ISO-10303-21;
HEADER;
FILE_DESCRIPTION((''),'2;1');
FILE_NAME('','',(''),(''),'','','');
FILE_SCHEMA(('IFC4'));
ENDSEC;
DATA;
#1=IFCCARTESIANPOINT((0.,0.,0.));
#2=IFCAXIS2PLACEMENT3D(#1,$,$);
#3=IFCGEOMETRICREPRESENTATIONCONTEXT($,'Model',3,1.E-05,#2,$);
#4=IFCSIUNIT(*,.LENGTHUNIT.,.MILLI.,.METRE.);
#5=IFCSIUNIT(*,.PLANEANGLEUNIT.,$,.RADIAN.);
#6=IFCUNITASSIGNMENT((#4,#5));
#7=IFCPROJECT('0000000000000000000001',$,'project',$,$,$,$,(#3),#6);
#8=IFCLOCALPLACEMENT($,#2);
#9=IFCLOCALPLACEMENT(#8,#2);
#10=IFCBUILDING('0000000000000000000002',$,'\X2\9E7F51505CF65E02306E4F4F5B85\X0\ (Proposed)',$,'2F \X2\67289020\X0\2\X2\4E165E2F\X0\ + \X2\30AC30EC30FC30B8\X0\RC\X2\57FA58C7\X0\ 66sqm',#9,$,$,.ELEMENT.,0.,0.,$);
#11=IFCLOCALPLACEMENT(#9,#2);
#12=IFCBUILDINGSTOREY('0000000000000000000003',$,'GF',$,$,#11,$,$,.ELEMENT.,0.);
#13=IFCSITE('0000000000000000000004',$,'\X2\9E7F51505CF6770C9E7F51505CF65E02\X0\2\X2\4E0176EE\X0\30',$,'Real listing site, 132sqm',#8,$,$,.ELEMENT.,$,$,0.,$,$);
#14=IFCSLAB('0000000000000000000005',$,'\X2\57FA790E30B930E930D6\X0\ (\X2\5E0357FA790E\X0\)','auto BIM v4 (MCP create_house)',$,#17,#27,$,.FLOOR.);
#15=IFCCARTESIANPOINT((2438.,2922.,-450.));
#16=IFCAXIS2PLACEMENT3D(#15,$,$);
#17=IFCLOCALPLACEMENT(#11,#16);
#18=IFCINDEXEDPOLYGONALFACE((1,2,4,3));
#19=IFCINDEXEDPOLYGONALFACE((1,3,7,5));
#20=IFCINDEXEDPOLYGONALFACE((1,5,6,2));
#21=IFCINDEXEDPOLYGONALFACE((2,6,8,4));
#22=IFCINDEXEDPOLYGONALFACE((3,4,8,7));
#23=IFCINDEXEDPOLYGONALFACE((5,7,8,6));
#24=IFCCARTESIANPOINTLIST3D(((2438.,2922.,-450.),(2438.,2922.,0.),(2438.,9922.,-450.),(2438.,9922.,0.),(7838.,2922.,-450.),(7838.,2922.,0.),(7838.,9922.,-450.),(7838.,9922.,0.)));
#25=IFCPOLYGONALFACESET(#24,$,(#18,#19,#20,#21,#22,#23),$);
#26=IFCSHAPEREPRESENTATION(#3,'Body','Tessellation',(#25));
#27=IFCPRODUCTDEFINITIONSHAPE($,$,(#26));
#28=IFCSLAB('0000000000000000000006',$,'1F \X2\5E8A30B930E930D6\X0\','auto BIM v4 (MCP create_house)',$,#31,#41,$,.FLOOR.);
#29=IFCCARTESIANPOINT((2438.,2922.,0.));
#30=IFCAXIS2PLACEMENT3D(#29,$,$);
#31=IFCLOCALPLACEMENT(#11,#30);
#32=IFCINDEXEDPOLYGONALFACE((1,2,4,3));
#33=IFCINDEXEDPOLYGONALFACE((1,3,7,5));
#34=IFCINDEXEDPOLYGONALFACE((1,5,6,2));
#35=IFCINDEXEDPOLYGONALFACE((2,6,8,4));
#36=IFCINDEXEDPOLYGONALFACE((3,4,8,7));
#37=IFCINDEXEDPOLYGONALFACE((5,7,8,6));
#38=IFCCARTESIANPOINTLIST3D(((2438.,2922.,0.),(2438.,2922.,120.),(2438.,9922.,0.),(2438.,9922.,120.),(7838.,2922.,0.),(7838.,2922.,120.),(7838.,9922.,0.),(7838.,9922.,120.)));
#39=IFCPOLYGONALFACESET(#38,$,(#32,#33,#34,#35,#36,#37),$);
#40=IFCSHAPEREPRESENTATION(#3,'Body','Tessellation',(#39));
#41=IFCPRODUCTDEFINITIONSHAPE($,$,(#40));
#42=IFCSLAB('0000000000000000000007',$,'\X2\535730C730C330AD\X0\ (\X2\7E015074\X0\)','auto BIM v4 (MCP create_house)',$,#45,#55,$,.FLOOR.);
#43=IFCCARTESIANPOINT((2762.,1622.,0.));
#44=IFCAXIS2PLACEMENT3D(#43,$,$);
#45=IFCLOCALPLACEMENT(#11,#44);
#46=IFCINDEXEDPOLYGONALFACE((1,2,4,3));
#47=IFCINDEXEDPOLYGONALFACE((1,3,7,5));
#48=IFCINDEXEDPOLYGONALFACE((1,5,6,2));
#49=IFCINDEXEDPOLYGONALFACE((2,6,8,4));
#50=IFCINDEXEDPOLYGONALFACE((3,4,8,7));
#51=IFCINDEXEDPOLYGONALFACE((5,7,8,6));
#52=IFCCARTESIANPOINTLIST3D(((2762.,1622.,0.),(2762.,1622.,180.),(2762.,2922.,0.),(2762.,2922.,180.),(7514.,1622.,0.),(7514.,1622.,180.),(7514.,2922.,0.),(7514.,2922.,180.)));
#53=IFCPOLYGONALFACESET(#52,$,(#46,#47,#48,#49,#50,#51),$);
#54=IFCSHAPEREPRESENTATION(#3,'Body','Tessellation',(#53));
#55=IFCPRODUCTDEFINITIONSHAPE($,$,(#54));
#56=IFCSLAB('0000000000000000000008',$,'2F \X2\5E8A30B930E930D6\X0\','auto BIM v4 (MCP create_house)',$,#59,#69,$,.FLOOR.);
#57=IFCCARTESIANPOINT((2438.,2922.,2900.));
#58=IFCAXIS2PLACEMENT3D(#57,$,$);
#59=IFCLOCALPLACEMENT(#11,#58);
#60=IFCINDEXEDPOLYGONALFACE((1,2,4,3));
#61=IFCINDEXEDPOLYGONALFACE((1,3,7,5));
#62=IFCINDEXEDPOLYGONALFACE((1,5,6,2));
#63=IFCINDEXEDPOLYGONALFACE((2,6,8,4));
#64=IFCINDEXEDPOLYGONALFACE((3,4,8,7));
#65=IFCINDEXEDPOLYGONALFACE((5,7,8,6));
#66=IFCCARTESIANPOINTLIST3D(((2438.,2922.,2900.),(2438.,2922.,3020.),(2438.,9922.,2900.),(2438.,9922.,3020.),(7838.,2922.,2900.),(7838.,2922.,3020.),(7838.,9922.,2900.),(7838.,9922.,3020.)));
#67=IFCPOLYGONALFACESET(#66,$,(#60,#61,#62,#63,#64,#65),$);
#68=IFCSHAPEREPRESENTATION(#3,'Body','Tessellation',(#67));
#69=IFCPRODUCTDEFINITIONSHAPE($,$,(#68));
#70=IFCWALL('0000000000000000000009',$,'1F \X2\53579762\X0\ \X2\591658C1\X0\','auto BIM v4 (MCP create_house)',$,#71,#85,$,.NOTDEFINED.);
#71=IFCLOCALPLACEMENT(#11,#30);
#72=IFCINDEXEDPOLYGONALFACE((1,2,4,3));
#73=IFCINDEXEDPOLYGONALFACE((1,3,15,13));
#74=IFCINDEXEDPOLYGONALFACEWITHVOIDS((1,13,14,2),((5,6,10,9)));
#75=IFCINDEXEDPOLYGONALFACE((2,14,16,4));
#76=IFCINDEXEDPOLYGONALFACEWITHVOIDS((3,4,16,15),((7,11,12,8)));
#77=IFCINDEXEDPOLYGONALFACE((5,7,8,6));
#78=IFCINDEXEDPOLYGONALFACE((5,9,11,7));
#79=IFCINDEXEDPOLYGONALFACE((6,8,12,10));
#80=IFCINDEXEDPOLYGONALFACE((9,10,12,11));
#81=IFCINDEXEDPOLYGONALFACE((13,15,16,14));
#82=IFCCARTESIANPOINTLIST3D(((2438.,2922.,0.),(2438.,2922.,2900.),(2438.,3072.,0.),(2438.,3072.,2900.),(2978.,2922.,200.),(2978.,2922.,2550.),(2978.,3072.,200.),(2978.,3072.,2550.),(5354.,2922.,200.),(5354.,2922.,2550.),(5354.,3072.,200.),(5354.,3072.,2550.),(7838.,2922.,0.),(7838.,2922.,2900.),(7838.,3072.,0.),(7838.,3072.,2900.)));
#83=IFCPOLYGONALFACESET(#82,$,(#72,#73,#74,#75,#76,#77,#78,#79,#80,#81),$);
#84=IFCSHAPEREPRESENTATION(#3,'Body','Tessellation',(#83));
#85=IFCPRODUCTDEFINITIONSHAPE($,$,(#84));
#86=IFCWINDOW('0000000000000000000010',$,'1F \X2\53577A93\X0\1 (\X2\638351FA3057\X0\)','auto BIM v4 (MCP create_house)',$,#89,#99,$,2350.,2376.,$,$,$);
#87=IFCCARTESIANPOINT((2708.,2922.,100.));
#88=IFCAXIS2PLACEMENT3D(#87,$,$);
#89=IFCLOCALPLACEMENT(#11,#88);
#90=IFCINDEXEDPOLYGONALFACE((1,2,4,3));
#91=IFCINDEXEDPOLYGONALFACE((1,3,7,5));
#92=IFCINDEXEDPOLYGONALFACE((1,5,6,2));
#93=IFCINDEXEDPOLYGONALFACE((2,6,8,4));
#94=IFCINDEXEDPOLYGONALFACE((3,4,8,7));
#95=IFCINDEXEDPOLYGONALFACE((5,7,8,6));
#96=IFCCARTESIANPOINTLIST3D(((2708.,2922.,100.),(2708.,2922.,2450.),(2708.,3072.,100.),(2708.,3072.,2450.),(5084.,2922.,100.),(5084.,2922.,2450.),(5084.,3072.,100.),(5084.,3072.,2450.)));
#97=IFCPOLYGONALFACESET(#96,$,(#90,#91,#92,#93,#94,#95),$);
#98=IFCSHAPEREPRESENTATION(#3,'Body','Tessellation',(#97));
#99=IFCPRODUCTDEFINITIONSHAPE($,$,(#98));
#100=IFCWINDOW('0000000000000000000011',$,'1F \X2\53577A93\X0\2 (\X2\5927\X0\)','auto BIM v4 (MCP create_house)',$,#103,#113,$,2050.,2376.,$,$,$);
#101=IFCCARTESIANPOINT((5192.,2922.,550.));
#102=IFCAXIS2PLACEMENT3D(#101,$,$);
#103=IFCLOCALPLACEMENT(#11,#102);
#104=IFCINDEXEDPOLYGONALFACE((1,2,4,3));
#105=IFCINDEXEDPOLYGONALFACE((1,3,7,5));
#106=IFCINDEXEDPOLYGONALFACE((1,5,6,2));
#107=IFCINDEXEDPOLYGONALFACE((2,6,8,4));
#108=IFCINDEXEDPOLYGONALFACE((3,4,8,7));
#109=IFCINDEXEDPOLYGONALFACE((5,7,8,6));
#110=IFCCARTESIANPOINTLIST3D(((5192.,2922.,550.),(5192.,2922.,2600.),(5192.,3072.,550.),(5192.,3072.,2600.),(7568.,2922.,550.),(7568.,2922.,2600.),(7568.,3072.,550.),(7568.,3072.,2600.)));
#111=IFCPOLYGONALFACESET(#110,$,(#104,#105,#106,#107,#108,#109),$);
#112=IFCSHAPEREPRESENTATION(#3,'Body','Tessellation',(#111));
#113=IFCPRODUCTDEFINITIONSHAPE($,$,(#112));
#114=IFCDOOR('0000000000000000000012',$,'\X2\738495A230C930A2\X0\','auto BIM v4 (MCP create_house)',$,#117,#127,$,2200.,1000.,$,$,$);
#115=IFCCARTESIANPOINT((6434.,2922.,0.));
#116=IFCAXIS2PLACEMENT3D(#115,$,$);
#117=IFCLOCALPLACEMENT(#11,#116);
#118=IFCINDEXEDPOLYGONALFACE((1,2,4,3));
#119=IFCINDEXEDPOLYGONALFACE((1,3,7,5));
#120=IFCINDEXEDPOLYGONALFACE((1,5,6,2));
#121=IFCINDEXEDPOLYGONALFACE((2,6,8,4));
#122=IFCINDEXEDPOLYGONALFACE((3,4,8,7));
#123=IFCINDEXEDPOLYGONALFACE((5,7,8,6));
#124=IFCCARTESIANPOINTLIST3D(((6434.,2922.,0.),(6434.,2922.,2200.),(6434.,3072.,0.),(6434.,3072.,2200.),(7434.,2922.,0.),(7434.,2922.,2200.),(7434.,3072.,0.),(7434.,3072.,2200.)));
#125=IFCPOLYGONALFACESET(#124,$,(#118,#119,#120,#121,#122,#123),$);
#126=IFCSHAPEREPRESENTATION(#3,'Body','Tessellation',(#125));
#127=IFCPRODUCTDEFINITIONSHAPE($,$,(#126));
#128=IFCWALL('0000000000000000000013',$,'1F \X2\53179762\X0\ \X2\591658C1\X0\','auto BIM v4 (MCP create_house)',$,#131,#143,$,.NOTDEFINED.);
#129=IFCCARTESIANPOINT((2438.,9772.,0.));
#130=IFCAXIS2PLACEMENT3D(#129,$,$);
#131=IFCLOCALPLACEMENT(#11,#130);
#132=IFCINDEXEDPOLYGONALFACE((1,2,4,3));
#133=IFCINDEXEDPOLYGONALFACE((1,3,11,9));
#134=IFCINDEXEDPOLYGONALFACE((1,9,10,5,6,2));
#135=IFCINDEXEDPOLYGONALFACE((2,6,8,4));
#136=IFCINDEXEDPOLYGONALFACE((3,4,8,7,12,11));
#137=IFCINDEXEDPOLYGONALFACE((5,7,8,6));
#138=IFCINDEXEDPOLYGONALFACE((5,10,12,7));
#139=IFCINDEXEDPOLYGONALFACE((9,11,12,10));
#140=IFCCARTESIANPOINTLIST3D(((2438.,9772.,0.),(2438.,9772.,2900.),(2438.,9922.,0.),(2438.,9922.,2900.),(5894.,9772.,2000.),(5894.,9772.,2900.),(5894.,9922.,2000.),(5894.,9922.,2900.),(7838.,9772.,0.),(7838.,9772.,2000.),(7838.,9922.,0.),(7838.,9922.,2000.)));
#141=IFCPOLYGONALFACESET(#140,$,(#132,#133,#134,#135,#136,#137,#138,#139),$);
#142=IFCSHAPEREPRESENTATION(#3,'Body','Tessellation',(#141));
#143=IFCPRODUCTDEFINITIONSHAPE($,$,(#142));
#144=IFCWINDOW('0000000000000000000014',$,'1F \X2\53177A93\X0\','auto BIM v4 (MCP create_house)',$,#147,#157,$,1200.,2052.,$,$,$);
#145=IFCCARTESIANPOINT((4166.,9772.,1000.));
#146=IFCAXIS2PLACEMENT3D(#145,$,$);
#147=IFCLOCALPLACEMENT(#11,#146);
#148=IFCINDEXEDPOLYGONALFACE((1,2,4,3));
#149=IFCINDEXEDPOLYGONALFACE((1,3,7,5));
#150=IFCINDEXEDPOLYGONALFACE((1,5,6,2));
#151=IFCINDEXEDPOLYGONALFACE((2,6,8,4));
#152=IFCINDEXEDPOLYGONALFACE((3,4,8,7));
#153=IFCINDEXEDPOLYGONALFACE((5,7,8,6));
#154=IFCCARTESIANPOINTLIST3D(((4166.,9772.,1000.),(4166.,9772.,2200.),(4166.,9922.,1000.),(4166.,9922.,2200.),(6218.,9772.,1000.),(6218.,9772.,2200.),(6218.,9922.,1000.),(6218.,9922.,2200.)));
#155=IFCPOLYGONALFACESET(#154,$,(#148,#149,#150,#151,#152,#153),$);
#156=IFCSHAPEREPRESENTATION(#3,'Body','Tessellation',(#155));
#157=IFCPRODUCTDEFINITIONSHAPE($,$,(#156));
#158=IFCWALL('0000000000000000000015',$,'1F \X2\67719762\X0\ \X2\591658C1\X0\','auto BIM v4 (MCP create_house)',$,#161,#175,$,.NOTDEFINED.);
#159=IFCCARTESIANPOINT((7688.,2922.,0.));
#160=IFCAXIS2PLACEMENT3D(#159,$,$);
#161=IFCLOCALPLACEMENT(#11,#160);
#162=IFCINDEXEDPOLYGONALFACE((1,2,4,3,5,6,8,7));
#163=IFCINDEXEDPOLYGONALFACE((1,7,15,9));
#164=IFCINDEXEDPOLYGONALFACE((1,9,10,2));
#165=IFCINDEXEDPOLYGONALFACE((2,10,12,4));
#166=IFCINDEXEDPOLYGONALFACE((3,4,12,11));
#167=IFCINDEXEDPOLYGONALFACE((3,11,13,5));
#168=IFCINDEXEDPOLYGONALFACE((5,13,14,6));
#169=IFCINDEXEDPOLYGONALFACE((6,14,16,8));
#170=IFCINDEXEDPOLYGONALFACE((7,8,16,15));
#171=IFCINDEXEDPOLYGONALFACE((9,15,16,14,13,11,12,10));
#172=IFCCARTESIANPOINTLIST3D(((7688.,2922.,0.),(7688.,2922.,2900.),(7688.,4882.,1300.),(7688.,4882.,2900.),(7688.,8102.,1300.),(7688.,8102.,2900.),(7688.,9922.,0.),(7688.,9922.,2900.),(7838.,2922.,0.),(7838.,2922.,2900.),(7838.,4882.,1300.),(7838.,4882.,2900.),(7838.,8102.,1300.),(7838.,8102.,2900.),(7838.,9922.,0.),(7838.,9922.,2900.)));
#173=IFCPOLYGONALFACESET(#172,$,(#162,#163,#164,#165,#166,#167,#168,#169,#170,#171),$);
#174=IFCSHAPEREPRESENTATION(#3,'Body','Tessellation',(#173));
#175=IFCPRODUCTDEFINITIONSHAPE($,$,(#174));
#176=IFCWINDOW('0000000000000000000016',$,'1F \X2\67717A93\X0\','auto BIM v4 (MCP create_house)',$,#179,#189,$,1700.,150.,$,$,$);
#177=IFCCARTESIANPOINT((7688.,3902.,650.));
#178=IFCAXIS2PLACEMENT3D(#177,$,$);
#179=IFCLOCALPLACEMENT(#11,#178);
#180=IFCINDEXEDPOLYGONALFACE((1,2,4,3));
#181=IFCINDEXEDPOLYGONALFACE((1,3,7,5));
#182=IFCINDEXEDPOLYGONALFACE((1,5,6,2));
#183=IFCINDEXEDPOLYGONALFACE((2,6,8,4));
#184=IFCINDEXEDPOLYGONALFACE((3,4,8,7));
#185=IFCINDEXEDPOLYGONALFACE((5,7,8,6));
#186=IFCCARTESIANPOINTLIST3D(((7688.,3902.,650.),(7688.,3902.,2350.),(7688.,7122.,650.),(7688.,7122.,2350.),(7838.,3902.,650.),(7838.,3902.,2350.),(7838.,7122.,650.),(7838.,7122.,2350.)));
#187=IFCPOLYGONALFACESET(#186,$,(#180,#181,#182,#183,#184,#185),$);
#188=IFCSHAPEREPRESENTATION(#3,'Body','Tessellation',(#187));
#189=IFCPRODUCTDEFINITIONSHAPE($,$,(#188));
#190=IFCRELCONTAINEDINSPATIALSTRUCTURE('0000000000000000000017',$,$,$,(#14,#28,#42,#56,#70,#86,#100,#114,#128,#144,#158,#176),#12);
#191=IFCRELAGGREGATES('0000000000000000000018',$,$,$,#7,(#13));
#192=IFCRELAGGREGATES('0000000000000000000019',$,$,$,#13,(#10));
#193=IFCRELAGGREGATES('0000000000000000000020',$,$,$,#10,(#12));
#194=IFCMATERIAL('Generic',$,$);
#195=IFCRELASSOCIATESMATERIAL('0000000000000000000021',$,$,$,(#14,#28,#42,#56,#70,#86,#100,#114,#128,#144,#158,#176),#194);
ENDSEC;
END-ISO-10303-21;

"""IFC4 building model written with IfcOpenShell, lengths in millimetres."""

from ifc_helpers import new_model, si_unit, frame, frame_2d, origin, place, context, project, spatial, rectangle, extrude, material, element, fill, save


model = new_model("IFC4")

# Units and contexts
model_context = context("Model", 3, precision=1e-05, world=origin())
ifc_project = project(units=[si_unit("LENGTHUNIT", "METRE", prefix="MILLI"), si_unit("PLANEANGLEUNIT", "RADIAN")], contexts=[model_context])

# Site, building, storey
site_placement = place(None, origin())
site = spatial("IfcSite", under=ifc_project, at=site_placement, Name="鹿児島県鹿児島市2丁目30", ObjectType="Real listing site, 132sqm", CompositionType="ELEMENT", RefElevation=0.0)
building_placement = place(site_placement, origin())
building = spatial("IfcBuilding", under=site, at=building_placement, Name="鹿児島市の住宅 (Proposed)", ObjectType="2F 木造2世帯 + ガレージRC基壇 66sqm", CompositionType="ELEMENT", ElevationOfRefHeight=0.0, ElevationOfTerrain=0.0)
storey_placement = place(building_placement, origin())
storey = spatial("IfcBuildingStorey", under=building, at=storey_placement, Name="GF", CompositionType="ELEMENT", Elevation=0.0)

# Slabs
ifc_material = material(Name="Generic")
slab_1_placement = place(storey_placement, frame((2438.0, 2922.0, -450.0)))
element("IfcSlab", 1, at=slab_1_placement, inside=storey, material=ifc_material, Name="基礎スラブ (布基礎)", Description="auto BIM v4 (MCP create_house)", PredefinedType="FLOOR", context=model_context, shape_type="SweptSolid", body=[
    extrude(rectangle(XDim=5400.0, YDim=7000.0, at=frame_2d((2700.0, 3500.0))), frame((2438.0, 2922.0, -450.0)), (0.0, 0.0, 1.0), 450.0),
])
slab_2_placement = place(storey_placement, frame((2438.0, 2922.0, 0.0)))
element("IfcSlab", 2, at=slab_2_placement, inside=storey, material=ifc_material, Name="1F 床スラブ", Description="auto BIM v4 (MCP create_house)", PredefinedType="FLOOR", context=model_context, shape_type="SweptSolid", body=[
    extrude(rectangle(XDim=5400.0, YDim=7000.0, at=frame_2d((2700.0, 3500.0))), frame((2438.0, 2922.0, 0.0)), (0.0, 0.0, 1.0), 120.0),
])
slab_3_placement = place(storey_placement, frame((2762.0, 1622.0, 0.0)))
element("IfcSlab", 3, at=slab_3_placement, inside=storey, material=ifc_material, Name="南デッキ (縁側)", Description="auto BIM v4 (MCP create_house)", PredefinedType="FLOOR", context=model_context, shape_type="SweptSolid", body=[
    extrude(rectangle(XDim=4752.0, YDim=1300.0, at=frame_2d((2376.0, 650.0))), frame((2762.0, 1622.0, 0.0)), (0.0, 0.0, 1.0), 180.0),
])
slab_4_placement = place(storey_placement, frame((2438.0, 2922.0, 2900.0)))
element("IfcSlab", 4, at=slab_4_placement, inside=storey, material=ifc_material, Name="2F 床スラブ", Description="auto BIM v4 (MCP create_house)", PredefinedType="FLOOR", context=model_context, shape_type="SweptSolid", body=[
    extrude(rectangle(XDim=5400.0, YDim=7000.0, at=frame_2d((2700.0, 3500.0))), frame((2438.0, 2922.0, 2900.0)), (0.0, 0.0, 1.0), 120.0),
])

# Wall, openings, windows, door
wall_1_placement = place(storey_placement, frame((2438.0, 2922.0, 0.0)))
wall_1 = element("IfcWall", 5, at=wall_1_placement, inside=storey, material=ifc_material, Name="1F 南面 外壁", Description="auto BIM v4 (MCP create_house)", PredefinedType="NOTDEFINED", context=model_context, shape_type="SweptSolid", body=[
    extrude(rectangle(XDim=5400.0, YDim=150.0, at=frame_2d((2700.0, 75.0))), frame((2438.0, 2922.0, 0.0)), (0.0, 0.0, 1.0), 2900.0),
])
opening_1_placement = place(storey_placement, frame((2708.0, 2922.0, 100.0)))
opening_1 = element("IfcOpeningElement", 6, at=opening_1_placement, cuts=wall_1, PredefinedType="NOTDEFINED", context=model_context, shape_type="SweptSolid", body=[
    extrude(rectangle(XDim=2376.0, YDim=150.0, at=frame_2d((1188.0, 75.0))), frame((2708.0, 2922.0, 100.0)), (0.0, 0.0, 1.0), 2350.0),
])
opening_2_placement = place(storey_placement, frame((5192.0, 2922.0, 550.0)))
opening_2 = element("IfcOpeningElement", 7, at=opening_2_placement, cuts=wall_1, PredefinedType="NOTDEFINED", context=model_context, shape_type="SweptSolid", body=[
    extrude(rectangle(XDim=2376.0, YDim=150.0, at=frame_2d((1188.0, 75.0))), frame((5192.0, 2922.0, 550.0)), (0.0, 0.0, 1.0), 2050.0),
])
opening_3_placement = place(storey_placement, frame((6434.0, 2922.0, 0.0)))
opening_3 = element("IfcOpeningElement", 8, at=opening_3_placement, cuts=wall_1, PredefinedType="NOTDEFINED", context=model_context, shape_type="SweptSolid", body=[
    extrude(rectangle(XDim=1000.0, YDim=150.0, at=frame_2d((500.0, 75.0))), frame((6434.0, 2922.0, 0.0)), (0.0, 0.0, 1.0), 2200.0),
])
window_1_placement = place(storey_placement, frame((2708.0, 2922.0, 100.0)))
window_1 = element("IfcWindow", 9, at=window_1_placement, inside=storey, material=ifc_material, Name="1F 南窓1 (掃出し)", Description="auto BIM v4 (MCP create_house)", OverallHeight=2350.0, OverallWidth=2376.0, context=model_context, shape_type="SweptSolid", body=[
    extrude(rectangle(XDim=2376.0, YDim=150.0, at=frame_2d((1188.0, 75.0))), frame((2708.0, 2922.0, 100.0)), (0.0, 0.0, 1.0), 2350.0),
])
fill(opening_1, window_1)
window_2_placement = place(storey_placement, frame((5192.0, 2922.0, 550.0)))
window_2 = element("IfcWindow", 10, at=window_2_placement, inside=storey, material=ifc_material, Name="1F 南窓2 (大)", Description="auto BIM v4 (MCP create_house)", OverallHeight=2050.0, OverallWidth=2376.0, context=model_context, shape_type="SweptSolid", body=[
    extrude(rectangle(XDim=2376.0, YDim=150.0, at=frame_2d((1188.0, 75.0))), frame((5192.0, 2922.0, 550.0)), (0.0, 0.0, 1.0), 2050.0),
])
fill(opening_2, window_2)
door_1_placement = place(storey_placement, frame((6434.0, 2922.0, 0.0)))
door_1 = element("IfcDoor", 11, at=door_1_placement, inside=storey, material=ifc_material, Name="玄関ドア", Description="auto BIM v4 (MCP create_house)", OverallHeight=2200.0, OverallWidth=1000.0, context=model_context, shape_type="SweptSolid", body=[
    extrude(rectangle(XDim=1000.0, YDim=150.0, at=frame_2d((500.0, 75.0))), frame((6434.0, 2922.0, 0.0)), (0.0, 0.0, 1.0), 2200.0),
])
fill(opening_3, door_1)

# Walls, openings, windows
wall_2_placement = place(storey_placement, frame((2438.0, 9772.0, 0.0)))
wall_2 = element("IfcWall", 12, at=wall_2_placement, inside=storey, material=ifc_material, Name="1F 北面 外壁", Description="auto BIM v4 (MCP create_house)", PredefinedType="NOTDEFINED", context=model_context, shape_type="SweptSolid", body=[
    extrude(rectangle(XDim=5400.0, YDim=150.0, at=frame_2d((2700.0, 75.0))), frame((2438.0, 9772.0, 0.0)), (0.0, 0.0, 1.0), 2900.0),
])
opening_4_placement = place(storey_placement, frame((4166.0, 9772.0, 1000.0)))
opening_4 = element("IfcOpeningElement", 13, at=opening_4_placement, cuts=wall_2, PredefinedType="NOTDEFINED", context=model_context, shape_type="SweptSolid", body=[
    extrude(rectangle(XDim=2052.0, YDim=150.0, at=frame_2d((1026.0, 75.0))), frame((4166.0, 9772.0, 1000.0)), (0.0, 0.0, 1.0), 1200.0),
])
window_3_placement = place(storey_placement, frame((4166.0, 9772.0, 1000.0)))
window_3 = element("IfcWindow", 14, at=window_3_placement, inside=storey, material=ifc_material, Name="1F 北窓", Description="auto BIM v4 (MCP create_house)", OverallHeight=1200.0, OverallWidth=2052.0, context=model_context, shape_type="SweptSolid", body=[
    extrude(rectangle(XDim=2052.0, YDim=150.0, at=frame_2d((1026.0, 75.0))), frame((4166.0, 9772.0, 1000.0)), (0.0, 0.0, 1.0), 1200.0),
])
fill(opening_4, window_3)
wall_3_placement = place(storey_placement, frame((7688.0, 2922.0, 0.0)))
wall_3 = element("IfcWall", 15, at=wall_3_placement, inside=storey, material=ifc_material, Name="1F 東面 外壁", Description="auto BIM v4 (MCP create_house)", PredefinedType="NOTDEFINED", context=model_context, shape_type="SweptSolid", body=[
    extrude(rectangle(XDim=150.0, YDim=7000.0, at=frame_2d((75.0, 3500.0))), frame((7688.0, 2922.0, 0.0)), (0.0, 0.0, 1.0), 2900.0),
])
opening_5_placement = place(storey_placement, frame((7688.0, 3902.0, 650.0)))
opening_5 = element("IfcOpeningElement", 16, at=opening_5_placement, cuts=wall_3, PredefinedType="NOTDEFINED", context=model_context, shape_type="SweptSolid", body=[
    extrude(rectangle(XDim=150.0, YDim=3220.0, at=frame_2d((75.0, 1610.0))), frame((7688.0, 3902.0, 650.0)), (0.0, 0.0, 1.0), 1700.0),
])
window_4_placement = place(storey_placement, frame((7688.0, 3902.0, 650.0)))
window_4 = element("IfcWindow", 17, at=window_4_placement, inside=storey, material=ifc_material, Name="1F 東窓", Description="auto BIM v4 (MCP create_house)", OverallHeight=1700.0, OverallWidth=150.0, context=model_context, shape_type="SweptSolid", body=[
    extrude(rectangle(XDim=150.0, YDim=3220.0, at=frame_2d((75.0, 1610.0))), frame((7688.0, 3902.0, 650.0)), (0.0, 0.0, 1.0), 1700.0),
])
fill(opening_5, window_4)

save(model, "model.ifc")
